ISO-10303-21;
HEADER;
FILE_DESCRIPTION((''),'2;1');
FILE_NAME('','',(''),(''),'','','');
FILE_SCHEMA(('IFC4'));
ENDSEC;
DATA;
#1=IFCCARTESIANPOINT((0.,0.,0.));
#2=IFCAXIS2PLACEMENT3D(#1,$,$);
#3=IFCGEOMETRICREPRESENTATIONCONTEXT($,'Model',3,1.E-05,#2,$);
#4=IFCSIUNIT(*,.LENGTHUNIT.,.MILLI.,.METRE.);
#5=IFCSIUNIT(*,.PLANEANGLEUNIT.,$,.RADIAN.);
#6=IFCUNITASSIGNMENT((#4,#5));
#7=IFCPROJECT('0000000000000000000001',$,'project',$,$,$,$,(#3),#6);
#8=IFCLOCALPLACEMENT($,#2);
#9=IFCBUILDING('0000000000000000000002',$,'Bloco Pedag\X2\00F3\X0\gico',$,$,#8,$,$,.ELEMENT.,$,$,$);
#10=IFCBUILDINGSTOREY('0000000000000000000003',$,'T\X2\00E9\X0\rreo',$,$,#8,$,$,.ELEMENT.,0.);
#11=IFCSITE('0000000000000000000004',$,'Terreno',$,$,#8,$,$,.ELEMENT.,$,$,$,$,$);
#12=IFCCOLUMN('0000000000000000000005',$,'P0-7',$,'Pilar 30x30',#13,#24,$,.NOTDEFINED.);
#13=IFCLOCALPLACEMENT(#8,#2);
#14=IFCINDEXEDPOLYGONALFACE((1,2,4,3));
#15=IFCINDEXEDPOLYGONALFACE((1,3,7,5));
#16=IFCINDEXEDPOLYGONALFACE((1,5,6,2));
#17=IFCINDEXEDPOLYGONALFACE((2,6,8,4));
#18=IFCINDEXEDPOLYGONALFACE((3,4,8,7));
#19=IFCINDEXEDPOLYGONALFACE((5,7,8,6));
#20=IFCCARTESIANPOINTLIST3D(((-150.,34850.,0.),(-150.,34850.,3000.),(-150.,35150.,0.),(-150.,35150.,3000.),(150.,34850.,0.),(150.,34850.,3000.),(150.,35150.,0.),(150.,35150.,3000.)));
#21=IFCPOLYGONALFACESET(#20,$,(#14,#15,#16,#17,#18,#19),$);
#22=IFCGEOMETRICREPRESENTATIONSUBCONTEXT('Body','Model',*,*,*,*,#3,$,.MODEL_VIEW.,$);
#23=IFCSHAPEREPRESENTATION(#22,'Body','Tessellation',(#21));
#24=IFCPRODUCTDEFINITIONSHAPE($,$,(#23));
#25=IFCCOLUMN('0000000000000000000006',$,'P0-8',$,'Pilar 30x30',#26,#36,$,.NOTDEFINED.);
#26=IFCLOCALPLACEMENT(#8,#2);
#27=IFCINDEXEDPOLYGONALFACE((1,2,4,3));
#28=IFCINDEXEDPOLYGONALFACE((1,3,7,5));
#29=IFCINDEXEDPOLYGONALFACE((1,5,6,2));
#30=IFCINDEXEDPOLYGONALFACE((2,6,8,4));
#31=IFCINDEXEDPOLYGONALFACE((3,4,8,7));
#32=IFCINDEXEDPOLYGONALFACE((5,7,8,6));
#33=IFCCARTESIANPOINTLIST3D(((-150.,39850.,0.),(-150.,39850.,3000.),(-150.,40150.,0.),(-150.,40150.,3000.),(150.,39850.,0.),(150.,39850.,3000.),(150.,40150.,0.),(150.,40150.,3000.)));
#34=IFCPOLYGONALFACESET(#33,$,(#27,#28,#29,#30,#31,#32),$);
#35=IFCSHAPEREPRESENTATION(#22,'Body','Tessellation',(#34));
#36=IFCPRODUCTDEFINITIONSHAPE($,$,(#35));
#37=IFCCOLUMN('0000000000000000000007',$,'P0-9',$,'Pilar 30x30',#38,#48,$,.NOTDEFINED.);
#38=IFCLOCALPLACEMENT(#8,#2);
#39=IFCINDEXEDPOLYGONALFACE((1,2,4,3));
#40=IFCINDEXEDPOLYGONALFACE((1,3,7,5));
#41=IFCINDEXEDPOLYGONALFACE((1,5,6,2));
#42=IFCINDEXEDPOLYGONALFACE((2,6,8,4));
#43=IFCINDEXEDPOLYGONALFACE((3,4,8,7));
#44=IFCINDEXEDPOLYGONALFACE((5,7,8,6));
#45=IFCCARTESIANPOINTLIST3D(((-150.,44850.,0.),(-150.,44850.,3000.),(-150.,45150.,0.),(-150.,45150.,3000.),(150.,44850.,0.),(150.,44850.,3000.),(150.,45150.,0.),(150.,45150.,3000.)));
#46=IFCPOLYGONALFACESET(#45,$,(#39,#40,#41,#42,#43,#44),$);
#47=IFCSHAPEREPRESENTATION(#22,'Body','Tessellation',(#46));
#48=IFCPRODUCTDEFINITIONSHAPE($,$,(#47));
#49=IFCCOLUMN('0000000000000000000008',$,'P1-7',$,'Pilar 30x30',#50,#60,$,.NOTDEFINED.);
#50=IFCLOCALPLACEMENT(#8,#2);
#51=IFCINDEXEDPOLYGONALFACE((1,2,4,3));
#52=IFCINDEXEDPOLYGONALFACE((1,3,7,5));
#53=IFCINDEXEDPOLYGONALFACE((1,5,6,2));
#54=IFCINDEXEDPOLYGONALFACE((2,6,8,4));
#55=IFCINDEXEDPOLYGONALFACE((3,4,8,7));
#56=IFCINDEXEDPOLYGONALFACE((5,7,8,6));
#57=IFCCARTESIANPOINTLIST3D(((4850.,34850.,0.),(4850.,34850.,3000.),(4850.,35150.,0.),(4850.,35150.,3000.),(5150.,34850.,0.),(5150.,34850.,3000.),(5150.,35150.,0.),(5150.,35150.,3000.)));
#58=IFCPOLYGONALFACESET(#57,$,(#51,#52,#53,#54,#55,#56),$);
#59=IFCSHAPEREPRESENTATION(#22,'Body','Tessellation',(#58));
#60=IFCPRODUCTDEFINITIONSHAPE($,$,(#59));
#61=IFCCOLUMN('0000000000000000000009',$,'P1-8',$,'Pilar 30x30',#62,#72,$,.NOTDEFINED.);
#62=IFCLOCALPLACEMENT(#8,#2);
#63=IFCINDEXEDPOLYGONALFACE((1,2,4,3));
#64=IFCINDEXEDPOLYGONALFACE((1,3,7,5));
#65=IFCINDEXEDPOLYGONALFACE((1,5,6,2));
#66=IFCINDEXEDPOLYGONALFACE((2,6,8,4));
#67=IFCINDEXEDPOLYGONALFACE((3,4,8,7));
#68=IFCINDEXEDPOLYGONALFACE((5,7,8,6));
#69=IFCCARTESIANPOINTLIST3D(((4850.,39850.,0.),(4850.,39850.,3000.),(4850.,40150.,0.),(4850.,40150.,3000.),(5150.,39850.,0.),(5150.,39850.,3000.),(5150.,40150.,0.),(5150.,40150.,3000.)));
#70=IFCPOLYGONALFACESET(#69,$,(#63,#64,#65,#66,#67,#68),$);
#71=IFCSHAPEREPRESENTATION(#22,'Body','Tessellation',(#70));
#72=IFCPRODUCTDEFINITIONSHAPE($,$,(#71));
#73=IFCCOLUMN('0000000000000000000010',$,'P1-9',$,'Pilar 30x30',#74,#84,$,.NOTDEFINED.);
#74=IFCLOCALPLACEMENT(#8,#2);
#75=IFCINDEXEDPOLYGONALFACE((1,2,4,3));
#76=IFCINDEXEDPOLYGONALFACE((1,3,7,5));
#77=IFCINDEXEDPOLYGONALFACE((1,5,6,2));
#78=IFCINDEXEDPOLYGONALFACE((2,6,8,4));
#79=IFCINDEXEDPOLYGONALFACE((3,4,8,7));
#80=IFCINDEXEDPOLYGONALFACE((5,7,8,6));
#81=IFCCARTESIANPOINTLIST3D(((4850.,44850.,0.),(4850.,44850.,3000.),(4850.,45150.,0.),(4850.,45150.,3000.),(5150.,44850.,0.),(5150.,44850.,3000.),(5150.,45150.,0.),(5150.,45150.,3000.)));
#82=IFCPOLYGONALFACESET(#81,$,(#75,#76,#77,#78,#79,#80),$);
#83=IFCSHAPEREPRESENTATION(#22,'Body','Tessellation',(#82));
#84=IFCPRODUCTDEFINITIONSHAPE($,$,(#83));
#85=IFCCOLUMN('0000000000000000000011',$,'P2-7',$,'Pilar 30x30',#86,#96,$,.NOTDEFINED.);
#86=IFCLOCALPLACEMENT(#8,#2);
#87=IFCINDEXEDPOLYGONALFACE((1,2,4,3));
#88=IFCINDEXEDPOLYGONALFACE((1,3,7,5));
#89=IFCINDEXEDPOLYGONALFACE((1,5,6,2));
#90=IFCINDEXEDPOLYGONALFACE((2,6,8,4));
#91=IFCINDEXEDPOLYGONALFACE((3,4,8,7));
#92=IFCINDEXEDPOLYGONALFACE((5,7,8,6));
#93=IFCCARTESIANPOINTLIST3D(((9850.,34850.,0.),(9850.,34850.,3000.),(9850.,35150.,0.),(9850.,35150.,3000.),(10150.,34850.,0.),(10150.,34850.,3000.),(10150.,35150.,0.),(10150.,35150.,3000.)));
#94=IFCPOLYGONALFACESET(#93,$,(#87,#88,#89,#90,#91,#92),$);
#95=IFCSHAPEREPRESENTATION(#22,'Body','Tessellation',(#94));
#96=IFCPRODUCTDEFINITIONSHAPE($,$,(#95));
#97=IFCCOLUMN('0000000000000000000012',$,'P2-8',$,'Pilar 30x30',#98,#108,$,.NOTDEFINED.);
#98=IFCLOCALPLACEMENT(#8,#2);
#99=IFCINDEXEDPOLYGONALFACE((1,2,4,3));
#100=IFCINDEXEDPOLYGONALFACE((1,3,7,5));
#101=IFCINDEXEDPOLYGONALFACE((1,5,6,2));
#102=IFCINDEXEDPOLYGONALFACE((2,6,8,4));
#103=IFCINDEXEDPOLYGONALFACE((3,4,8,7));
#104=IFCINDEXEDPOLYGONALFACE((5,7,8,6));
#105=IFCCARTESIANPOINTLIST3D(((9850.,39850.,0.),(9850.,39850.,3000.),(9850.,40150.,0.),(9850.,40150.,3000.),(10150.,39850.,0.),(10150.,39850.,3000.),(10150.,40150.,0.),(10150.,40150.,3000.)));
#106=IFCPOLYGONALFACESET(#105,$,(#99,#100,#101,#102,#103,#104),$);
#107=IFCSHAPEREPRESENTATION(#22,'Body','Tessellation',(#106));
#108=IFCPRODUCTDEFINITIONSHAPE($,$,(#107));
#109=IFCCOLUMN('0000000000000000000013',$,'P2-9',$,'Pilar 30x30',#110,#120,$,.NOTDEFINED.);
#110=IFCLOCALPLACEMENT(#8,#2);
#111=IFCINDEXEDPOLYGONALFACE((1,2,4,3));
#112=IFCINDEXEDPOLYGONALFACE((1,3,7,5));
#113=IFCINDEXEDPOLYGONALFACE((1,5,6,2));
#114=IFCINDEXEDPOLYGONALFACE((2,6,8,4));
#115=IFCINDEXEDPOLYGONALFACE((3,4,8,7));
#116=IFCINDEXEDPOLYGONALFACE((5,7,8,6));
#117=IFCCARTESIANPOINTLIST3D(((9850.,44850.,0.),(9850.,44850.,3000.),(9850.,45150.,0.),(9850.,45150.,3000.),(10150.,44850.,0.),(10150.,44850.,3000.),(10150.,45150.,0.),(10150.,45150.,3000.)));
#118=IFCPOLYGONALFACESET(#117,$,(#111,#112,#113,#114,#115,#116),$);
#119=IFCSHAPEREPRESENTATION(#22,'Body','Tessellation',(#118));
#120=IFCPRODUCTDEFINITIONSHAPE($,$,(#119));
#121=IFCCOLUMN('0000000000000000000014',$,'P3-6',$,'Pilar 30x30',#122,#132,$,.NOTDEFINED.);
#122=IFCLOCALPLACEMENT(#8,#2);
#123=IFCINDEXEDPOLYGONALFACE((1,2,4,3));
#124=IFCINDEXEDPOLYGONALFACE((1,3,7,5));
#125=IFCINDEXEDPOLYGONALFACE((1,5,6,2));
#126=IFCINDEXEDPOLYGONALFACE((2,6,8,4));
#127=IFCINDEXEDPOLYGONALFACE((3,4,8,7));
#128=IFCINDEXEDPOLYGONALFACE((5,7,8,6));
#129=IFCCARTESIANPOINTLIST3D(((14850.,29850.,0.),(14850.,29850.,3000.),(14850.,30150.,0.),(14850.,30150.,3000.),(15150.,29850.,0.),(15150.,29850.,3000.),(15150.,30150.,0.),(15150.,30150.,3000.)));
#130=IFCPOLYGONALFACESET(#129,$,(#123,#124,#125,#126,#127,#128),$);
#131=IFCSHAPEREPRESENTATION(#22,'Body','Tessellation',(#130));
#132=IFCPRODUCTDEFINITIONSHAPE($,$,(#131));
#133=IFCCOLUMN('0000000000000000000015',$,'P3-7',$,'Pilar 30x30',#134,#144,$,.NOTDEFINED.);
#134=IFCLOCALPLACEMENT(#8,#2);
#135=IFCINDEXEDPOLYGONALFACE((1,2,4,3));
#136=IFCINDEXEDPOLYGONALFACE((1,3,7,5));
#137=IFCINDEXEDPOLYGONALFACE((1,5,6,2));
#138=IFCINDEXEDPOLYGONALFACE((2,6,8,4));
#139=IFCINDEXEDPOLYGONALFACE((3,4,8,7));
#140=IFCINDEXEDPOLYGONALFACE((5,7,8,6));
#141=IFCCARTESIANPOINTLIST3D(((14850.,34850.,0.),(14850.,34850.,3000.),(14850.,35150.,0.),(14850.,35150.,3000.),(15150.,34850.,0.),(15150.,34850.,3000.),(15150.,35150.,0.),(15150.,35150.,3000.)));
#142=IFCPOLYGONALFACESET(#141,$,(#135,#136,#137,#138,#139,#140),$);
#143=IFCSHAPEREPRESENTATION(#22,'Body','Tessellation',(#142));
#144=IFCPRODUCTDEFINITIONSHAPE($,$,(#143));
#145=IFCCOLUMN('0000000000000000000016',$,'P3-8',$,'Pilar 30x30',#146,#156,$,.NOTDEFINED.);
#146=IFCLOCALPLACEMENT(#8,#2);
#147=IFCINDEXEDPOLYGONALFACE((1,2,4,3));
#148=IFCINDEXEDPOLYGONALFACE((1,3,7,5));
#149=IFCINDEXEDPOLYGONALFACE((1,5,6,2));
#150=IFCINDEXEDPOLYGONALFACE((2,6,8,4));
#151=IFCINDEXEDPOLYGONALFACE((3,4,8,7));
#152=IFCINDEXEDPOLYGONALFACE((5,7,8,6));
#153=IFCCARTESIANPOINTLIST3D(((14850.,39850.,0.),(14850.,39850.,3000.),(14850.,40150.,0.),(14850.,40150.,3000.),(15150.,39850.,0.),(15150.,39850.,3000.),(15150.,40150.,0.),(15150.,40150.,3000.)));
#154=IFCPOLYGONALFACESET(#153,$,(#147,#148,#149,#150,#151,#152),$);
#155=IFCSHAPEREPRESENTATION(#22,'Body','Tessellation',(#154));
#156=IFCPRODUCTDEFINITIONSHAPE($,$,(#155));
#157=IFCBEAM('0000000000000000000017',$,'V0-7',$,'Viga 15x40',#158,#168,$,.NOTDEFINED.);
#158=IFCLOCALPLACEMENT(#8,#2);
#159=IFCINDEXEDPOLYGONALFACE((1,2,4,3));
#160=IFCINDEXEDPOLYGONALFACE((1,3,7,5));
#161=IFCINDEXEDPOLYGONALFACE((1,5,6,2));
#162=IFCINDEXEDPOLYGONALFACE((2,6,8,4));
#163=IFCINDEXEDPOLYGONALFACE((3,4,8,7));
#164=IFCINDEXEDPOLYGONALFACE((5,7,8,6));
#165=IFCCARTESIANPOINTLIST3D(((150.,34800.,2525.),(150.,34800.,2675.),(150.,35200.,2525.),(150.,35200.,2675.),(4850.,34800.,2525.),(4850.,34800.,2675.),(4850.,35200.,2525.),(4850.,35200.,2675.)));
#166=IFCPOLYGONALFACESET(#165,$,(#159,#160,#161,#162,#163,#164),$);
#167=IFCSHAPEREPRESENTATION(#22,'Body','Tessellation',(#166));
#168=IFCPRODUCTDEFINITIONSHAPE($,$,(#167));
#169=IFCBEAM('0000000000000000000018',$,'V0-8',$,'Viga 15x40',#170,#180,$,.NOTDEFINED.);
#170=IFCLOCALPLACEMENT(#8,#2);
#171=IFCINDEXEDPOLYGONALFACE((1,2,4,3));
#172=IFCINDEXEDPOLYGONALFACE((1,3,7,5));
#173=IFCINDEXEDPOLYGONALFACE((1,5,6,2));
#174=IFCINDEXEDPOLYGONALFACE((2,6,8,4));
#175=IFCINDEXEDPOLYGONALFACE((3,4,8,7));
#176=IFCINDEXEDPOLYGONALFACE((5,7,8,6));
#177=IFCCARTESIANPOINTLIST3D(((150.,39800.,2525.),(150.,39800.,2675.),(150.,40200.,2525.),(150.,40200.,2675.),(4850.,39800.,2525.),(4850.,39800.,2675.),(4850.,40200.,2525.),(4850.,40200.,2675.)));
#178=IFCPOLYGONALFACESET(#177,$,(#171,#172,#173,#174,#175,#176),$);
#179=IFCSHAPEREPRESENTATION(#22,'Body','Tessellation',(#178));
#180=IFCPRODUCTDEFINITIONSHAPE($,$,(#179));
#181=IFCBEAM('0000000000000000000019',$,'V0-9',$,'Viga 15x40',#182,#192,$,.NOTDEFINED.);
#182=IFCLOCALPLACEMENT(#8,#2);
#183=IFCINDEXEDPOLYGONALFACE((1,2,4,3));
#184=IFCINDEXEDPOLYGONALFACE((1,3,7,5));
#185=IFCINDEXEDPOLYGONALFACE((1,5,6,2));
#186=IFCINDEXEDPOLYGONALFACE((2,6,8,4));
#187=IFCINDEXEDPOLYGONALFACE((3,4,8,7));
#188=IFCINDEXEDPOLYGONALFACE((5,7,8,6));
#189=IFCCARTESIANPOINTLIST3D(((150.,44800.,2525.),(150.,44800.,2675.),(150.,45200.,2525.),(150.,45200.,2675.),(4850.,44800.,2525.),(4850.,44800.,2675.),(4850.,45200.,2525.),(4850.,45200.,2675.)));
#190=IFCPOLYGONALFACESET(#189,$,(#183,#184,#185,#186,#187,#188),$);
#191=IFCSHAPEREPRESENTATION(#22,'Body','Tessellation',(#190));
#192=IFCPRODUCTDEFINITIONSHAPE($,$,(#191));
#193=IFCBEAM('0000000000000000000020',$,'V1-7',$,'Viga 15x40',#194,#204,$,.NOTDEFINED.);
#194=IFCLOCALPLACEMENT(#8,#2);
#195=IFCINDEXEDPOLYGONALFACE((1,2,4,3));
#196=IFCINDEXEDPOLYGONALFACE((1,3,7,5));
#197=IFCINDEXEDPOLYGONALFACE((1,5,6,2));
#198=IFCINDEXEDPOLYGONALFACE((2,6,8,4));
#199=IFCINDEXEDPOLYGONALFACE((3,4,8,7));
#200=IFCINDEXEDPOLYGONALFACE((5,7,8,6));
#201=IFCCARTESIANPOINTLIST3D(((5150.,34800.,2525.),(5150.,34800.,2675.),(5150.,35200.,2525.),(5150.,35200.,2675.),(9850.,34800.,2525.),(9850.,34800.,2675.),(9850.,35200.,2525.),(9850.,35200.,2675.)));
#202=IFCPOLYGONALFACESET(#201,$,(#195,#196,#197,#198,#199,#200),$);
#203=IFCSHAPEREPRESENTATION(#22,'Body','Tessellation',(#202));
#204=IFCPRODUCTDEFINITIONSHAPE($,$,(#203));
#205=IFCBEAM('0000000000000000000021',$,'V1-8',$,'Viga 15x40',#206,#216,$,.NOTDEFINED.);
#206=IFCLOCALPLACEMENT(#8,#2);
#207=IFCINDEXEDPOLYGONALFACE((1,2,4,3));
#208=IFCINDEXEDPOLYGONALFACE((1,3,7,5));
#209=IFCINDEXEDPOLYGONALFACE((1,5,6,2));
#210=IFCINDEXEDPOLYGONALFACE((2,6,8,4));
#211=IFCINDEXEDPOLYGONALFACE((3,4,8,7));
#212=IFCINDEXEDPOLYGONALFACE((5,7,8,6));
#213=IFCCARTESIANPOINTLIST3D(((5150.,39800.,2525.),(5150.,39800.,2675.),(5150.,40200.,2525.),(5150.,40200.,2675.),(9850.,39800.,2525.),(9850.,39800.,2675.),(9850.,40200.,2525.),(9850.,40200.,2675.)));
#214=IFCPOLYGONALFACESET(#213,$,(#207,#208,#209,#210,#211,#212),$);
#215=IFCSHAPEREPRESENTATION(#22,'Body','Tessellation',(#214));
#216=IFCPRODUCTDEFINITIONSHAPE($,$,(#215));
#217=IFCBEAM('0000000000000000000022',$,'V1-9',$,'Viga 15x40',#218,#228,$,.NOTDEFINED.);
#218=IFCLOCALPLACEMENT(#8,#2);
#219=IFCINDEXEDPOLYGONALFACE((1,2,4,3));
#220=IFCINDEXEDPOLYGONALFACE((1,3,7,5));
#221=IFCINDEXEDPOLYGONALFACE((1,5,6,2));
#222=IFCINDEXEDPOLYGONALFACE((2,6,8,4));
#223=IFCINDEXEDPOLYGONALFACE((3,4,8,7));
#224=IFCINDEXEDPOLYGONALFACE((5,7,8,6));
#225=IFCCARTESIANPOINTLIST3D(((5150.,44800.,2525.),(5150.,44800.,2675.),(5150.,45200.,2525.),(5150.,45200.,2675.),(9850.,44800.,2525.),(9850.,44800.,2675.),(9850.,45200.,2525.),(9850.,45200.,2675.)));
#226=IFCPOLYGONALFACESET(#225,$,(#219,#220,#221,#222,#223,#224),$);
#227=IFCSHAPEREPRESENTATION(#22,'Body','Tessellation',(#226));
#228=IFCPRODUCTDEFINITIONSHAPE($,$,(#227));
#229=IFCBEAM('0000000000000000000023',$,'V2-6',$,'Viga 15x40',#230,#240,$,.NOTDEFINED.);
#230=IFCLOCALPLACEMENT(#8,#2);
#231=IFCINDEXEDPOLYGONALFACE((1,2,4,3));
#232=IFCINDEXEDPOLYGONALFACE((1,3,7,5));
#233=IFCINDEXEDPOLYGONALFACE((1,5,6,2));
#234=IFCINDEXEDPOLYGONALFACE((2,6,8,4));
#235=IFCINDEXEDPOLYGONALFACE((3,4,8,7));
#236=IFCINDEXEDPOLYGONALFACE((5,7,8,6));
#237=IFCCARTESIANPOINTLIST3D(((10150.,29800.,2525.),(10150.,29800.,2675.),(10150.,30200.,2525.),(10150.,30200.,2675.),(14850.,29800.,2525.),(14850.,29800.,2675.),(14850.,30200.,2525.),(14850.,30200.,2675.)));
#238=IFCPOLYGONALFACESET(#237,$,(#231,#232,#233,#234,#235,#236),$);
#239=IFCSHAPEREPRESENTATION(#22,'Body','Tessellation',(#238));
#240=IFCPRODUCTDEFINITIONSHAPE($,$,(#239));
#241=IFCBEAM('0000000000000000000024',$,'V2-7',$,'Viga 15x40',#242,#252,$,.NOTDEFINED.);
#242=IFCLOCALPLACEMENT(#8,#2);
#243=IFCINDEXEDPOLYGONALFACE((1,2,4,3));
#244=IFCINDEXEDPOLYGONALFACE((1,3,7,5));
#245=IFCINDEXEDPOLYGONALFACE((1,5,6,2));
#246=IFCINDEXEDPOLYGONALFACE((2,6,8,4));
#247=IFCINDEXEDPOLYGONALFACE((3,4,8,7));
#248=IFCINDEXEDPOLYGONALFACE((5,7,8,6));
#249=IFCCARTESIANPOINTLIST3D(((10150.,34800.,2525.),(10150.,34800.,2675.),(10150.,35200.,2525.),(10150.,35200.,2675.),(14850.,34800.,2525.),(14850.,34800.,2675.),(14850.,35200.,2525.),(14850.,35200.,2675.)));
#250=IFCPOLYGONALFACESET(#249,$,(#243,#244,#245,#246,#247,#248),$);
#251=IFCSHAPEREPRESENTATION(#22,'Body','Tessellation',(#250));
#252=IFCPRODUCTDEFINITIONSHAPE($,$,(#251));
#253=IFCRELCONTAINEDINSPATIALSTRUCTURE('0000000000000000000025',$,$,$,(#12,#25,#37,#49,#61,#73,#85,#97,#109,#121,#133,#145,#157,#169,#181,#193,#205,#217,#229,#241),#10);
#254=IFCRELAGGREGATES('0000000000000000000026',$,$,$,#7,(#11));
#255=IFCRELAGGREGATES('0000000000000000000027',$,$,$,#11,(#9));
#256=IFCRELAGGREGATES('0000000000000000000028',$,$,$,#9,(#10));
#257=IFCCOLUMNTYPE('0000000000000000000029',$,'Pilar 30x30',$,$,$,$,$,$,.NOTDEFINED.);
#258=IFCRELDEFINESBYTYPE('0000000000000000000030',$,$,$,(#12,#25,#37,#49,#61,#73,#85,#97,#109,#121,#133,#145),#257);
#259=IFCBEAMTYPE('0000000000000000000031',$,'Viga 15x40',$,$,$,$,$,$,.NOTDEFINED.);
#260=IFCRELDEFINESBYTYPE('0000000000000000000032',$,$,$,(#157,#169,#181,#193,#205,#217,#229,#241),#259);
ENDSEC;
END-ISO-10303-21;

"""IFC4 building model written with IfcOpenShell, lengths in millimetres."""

from ifc_helpers import new_model, si_unit, frame, origin, origin_2d, place, context, subcontext, project, spatial, rectangle, extrude, type_object, element, save


model = new_model("IFC4")

# Units and contexts
model_context = context("Model", 3, precision=1e-05, world=origin())
body_context = subcontext(model_context, "Body", "Model", "MODEL_VIEW")
ifc_project = project(units=[si_unit("LENGTHUNIT", "METRE", prefix="MILLI"), si_unit("PLANEANGLEUNIT", "RADIAN")], contexts=[model_context])

# Site, building, storey
placement = place(None, origin())
site = spatial("IfcSite", under=ifc_project, at=placement, Name="Terreno", CompositionType="ELEMENT")
building = spatial("IfcBuilding", under=site, at=placement, Name="Bloco Pedagógico", CompositionType="ELEMENT")
storey = spatial("IfcBuildingStorey", under=building, at=placement, Name="Térreo", CompositionType="ELEMENT", Elevation=0.0)

# Columns
column_type = type_object("IfcColumnType", Name="Pilar 30x30", PredefinedType="NOTDEFINED")
for number, where, z_axis, x_axis, name in (
    (1, (0.0, 35000.0, 0.0), (0.0, 0.0, 1.0), (1.0, 0.0, 0.0), "P0-7"),
    (2, (0.0, 40000.0, 0.0), (0.0, 0.0, 1.0), (1.0, 0.0, 0.0), "P0-8"),
    (3, (0.0, 45000.0, 0.0), (0.0, 0.0, 1.0), (1.0, 0.0, 0.0), "P0-9"),
    (4, (5000.0, 35000.0, 0.0), (0.0, 0.0, 1.0), (1.0, 0.0, 0.0), "P1-7"),
    (5, (5000.0, 40000.0, 0.0), (0.0, 0.0, 1.0), (1.0, 0.0, 0.0), "P1-8"),
    (6, (5000.0, 45000.0, 0.0), (0.0, 0.0, 1.0), (1.0, 0.0, 0.0), "P1-9"),
    (7, (10000.0, 35000.0, 0.0), (0.0, 0.0, 1.0), (1.0, 0.0, 0.0), "P2-7"),
    (8, (10000.0, 40000.0, 0.0), (0.0, 0.0, 1.0), (1.0, 0.0, 0.0), "P2-8"),
    (9, (10000.0, 45000.0, 0.0), (0.0, 0.0, 1.0), (1.0, 0.0, 0.0), "P2-9"),
    (10, (15000.0, 30000.0, 0.0), (0.0, 0.0, 1.0), (1.0, 0.0, 0.0), "P3-6"),
    (11, (15000.0, 35000.0, 0.0), (0.0, 0.0, 1.0), (1.0, 0.0, 0.0), "P3-7"),
    (12, (15000.0, 40000.0, 0.0), (0.0, 0.0, 1.0), (1.0, 0.0, 0.0), "P3-8"),
):
    element("IfcColumn", number, at=place(None, frame(where, z_axis=z_axis, x_axis=x_axis)), inside=storey, type_object=column_type, Name=name, ObjectType="Pilar 30x30", PredefinedType="NOTDEFINED", context=body_context, shape_type="SweptSolid", body=[
        extrude(rectangle(XDim=300.0, YDim=300.0, at=origin_2d()), None, (0.0, 0.0, 1.0), 3000.0),
    ])

# Beams
beam_type = type_object("IfcBeamType", Name="Viga 15x40", PredefinedType="NOTDEFINED")
for number, where, z_axis, x_axis, name in (
    (13, (150.0, 35000.0, 2600.0), (1.0, 0.0, 0.0), (0.0, 1.0, 0.0), "V0-7"),
    (14, (150.0, 40000.0, 2600.0), (1.0, 0.0, 0.0), (0.0, 1.0, 0.0), "V0-8"),
    (15, (150.0, 45000.0, 2600.0), (1.0, 0.0, 0.0), (0.0, 1.0, 0.0), "V0-9"),
    (16, (5150.0, 35000.0, 2600.0), (1.0, 0.0, 0.0), (0.0, 1.0, 0.0), "V1-7"),
    (17, (5150.0, 40000.0, 2600.0), (1.0, 0.0, 0.0), (0.0, 1.0, 0.0), "V1-8"),
    (18, (5150.0, 45000.0, 2600.0), (1.0, 0.0, 0.0), (0.0, 1.0, 0.0), "V1-9"),
    (19, (10150.0, 30000.0, 2600.0), (1.0, 0.0, 0.0), (0.0, 1.0, 0.0), "V2-6"),
    (20, (10150.0, 35000.0, 2600.0), (1.0, 0.0, 0.0), (0.0, 1.0, 0.0), "V2-7"),
):
    element("IfcBeam", number, at=place(None, frame(where, z_axis=z_axis, x_axis=x_axis)), inside=storey, type_object=beam_type, Name=name, ObjectType="Viga 15x40", PredefinedType="NOTDEFINED", context=body_context, shape_type="SweptSolid", body=[
        extrude(rectangle(XDim=400.0, YDim=150.0, at=origin_2d()), None, (0.0, 0.0, 1.0), 4700.0),
    ])

save(model, "model.ifc")
